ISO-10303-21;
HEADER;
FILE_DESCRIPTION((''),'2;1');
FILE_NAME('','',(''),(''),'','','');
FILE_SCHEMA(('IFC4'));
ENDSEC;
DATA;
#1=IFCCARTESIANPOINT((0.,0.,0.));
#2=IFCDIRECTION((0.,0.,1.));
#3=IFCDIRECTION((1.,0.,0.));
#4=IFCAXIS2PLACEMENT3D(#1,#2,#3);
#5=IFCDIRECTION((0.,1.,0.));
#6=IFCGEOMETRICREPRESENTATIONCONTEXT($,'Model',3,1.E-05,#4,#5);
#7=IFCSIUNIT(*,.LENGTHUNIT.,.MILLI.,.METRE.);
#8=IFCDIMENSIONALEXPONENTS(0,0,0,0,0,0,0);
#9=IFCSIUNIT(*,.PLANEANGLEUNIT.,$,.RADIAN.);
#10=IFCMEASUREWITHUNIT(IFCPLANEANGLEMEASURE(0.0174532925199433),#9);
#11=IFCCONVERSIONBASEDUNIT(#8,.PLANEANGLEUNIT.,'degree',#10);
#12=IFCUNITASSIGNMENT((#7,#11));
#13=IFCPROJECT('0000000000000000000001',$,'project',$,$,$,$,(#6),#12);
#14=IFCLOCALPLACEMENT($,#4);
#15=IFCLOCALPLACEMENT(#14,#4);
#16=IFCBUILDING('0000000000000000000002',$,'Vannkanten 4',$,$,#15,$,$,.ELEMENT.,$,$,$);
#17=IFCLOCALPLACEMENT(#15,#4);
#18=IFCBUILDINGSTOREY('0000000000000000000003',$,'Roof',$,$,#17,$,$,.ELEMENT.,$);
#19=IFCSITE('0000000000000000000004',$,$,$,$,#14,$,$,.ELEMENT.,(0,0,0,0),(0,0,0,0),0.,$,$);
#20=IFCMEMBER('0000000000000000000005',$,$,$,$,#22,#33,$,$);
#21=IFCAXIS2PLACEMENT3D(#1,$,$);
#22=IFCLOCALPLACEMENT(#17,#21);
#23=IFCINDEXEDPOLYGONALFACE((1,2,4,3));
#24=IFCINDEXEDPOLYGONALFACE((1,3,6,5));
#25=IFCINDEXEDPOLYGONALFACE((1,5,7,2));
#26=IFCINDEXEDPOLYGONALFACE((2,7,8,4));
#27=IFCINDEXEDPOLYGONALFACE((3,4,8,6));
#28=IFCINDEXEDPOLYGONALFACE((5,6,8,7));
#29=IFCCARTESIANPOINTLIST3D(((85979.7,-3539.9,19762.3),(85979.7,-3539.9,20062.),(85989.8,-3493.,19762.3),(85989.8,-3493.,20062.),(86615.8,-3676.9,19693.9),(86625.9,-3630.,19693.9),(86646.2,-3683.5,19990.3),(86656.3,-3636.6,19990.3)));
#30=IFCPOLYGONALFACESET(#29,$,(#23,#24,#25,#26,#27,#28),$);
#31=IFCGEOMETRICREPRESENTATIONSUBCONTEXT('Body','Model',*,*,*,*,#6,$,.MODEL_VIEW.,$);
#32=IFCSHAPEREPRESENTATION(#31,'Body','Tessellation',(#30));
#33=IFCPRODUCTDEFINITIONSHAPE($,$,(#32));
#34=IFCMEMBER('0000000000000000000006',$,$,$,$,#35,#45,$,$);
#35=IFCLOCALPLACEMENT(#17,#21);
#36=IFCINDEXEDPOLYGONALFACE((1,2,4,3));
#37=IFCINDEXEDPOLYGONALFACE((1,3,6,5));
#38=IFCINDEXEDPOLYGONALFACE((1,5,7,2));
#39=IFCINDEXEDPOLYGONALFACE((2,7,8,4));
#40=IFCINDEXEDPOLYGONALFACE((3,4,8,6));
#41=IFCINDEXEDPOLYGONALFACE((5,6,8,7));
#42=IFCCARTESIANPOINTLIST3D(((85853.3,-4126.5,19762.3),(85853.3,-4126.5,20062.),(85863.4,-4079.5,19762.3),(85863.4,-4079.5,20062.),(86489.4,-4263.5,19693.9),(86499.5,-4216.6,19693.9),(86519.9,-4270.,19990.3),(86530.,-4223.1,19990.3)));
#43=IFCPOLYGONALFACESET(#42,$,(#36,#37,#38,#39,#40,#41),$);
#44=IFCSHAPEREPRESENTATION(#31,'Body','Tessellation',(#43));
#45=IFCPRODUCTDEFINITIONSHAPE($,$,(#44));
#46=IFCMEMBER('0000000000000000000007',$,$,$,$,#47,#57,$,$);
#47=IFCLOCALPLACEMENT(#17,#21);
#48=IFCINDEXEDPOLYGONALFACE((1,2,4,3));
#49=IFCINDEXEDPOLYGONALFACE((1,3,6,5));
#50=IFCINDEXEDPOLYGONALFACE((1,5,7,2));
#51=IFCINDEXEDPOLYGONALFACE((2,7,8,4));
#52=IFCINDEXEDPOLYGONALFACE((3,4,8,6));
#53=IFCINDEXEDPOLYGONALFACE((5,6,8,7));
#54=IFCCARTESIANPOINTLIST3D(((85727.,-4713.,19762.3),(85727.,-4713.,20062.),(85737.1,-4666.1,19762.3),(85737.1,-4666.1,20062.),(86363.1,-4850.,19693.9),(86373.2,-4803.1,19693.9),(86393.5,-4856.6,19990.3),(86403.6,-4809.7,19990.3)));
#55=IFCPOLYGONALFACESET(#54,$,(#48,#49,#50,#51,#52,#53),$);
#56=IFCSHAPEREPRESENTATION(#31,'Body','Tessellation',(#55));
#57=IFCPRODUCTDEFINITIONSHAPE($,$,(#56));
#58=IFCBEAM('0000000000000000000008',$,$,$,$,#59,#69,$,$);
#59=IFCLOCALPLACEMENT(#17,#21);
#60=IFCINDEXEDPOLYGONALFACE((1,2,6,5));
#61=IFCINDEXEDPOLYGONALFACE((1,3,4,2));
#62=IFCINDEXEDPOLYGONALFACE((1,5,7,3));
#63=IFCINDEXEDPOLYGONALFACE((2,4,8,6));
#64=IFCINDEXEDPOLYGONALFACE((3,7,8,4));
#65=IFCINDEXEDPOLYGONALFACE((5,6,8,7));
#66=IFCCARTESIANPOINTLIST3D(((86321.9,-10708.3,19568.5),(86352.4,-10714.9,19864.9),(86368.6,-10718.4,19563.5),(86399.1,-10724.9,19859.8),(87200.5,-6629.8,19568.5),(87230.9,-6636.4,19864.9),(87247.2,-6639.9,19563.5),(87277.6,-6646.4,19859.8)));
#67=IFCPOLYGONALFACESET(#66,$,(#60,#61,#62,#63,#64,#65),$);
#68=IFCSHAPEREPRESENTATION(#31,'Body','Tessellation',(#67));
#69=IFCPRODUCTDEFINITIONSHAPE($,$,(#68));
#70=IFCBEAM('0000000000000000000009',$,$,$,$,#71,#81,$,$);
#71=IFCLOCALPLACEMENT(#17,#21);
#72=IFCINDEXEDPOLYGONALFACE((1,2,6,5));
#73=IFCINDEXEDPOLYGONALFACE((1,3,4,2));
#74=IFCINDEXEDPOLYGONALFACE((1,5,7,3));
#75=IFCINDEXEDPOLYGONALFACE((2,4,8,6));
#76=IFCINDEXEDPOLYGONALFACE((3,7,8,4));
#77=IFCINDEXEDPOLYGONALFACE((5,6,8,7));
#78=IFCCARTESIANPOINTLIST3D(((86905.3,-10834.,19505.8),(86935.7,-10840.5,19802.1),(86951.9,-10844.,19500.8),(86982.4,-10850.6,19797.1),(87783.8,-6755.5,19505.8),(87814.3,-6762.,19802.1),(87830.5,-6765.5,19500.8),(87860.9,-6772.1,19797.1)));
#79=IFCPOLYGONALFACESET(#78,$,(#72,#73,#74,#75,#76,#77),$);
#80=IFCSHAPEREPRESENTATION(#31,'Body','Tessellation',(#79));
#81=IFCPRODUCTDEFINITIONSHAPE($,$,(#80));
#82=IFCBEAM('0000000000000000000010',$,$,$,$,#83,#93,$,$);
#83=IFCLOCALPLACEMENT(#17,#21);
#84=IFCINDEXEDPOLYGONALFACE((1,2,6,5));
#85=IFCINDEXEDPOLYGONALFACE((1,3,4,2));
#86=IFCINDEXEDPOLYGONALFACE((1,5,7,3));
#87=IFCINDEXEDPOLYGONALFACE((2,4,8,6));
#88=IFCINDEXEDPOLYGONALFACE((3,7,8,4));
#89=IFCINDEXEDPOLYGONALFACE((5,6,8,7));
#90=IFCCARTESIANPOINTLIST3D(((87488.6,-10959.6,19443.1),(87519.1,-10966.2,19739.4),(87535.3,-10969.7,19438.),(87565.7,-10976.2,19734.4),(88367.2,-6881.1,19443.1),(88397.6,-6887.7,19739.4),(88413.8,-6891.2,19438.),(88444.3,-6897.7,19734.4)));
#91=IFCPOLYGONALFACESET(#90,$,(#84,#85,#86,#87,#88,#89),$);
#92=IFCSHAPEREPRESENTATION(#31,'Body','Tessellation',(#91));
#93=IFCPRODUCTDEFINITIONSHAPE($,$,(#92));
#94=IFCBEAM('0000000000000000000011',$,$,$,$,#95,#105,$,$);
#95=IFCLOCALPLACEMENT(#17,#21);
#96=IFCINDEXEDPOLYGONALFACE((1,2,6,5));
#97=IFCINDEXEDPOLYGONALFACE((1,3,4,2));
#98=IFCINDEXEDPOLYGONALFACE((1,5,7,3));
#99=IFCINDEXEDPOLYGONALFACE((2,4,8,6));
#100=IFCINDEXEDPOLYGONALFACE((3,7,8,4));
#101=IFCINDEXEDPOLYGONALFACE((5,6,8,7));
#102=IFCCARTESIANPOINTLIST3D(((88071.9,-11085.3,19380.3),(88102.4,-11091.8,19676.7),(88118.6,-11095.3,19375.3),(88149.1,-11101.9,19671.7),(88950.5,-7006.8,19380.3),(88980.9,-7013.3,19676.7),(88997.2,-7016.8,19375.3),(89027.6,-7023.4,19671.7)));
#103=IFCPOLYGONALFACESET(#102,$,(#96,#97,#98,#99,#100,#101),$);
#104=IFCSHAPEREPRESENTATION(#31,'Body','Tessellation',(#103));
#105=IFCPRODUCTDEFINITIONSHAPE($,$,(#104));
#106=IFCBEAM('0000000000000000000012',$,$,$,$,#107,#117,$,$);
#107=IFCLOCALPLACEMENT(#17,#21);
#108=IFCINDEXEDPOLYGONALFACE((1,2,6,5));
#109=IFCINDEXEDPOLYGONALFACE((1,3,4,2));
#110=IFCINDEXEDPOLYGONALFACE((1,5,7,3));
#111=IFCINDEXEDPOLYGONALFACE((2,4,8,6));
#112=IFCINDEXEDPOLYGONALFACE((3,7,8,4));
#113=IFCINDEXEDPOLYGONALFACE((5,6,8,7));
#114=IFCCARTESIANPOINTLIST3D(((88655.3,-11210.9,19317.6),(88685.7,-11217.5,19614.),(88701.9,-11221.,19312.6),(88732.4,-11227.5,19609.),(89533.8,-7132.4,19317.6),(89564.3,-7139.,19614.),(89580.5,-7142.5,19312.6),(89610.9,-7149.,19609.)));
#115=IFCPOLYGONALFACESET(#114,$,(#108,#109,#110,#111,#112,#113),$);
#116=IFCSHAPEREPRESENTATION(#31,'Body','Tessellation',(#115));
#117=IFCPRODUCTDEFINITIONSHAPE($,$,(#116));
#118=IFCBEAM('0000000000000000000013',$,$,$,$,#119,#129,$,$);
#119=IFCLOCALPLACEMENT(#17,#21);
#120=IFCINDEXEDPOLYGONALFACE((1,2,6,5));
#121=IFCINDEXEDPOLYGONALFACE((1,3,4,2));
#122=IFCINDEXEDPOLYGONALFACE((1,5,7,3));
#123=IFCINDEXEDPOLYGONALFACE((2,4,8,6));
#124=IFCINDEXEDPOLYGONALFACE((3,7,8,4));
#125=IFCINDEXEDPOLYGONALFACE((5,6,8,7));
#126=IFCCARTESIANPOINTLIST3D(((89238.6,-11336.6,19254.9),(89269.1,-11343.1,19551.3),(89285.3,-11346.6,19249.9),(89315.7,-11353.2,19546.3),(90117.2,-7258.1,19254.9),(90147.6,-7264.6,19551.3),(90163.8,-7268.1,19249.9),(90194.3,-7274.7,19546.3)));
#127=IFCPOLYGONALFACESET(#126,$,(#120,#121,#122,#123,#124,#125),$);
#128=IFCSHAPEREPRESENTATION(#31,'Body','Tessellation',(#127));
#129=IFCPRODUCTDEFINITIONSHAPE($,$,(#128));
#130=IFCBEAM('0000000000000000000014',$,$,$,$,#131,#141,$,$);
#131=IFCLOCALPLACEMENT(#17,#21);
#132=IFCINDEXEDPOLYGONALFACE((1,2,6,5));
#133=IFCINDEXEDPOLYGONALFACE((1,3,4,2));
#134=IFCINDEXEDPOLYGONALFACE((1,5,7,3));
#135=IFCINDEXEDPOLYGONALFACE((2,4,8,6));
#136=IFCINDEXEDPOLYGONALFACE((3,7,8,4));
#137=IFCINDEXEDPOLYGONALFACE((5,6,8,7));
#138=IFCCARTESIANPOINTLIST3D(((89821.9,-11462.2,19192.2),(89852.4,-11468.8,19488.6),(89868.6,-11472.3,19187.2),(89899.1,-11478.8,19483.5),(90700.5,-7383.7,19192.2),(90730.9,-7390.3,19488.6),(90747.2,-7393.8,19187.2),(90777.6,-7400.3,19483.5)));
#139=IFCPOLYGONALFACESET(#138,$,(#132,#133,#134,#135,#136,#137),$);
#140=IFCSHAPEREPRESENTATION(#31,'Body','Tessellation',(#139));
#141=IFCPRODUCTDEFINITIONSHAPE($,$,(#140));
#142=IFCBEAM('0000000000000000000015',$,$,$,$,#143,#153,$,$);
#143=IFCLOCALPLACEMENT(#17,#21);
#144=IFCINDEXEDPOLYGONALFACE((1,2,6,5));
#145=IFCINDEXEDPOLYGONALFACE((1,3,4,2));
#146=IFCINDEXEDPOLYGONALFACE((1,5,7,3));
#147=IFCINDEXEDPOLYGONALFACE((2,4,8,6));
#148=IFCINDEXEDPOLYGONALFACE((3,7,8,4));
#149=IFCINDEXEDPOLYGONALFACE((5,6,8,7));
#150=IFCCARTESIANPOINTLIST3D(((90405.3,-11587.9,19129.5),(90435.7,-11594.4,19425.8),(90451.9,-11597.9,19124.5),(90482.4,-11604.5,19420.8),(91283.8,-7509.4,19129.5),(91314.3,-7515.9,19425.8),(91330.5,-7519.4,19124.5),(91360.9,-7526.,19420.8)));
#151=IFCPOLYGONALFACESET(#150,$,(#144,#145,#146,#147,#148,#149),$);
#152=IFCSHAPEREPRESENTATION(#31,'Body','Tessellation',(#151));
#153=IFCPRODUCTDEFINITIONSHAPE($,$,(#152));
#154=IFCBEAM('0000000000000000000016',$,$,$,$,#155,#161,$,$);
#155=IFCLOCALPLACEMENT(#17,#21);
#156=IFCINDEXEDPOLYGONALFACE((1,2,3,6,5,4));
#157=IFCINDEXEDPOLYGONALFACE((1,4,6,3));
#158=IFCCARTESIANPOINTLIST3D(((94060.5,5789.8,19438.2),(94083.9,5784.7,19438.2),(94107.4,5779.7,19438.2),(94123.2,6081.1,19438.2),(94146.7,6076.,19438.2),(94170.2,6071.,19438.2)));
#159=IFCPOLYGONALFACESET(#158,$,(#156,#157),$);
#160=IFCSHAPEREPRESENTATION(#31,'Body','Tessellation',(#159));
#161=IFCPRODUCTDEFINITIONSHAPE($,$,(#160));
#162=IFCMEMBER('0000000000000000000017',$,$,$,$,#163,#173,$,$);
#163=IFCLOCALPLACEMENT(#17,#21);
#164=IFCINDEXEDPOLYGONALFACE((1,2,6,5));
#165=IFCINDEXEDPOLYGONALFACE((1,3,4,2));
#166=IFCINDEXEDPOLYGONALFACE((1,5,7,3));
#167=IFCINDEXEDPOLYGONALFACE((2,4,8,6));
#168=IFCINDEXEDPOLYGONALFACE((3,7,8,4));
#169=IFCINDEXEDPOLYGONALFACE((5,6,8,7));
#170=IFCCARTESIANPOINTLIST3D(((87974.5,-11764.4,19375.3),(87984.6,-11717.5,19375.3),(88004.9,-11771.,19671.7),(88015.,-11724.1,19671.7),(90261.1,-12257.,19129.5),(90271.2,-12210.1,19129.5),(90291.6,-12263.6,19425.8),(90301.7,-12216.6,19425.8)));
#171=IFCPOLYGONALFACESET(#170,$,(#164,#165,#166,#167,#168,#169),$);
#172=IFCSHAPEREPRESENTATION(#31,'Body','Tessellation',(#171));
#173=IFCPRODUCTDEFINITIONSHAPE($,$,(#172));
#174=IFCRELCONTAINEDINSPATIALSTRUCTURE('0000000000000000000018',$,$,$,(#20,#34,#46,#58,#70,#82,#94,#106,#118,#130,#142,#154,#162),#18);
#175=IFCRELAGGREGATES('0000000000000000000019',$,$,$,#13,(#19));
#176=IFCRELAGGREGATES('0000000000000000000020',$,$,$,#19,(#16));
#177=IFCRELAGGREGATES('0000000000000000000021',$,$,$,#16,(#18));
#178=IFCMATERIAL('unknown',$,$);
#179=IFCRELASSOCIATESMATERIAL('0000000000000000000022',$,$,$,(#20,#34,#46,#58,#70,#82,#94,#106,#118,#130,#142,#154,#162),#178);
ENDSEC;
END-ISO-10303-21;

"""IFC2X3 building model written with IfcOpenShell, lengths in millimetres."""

from ifc_helpers import new_model, entity, si_unit, converted_unit, direction, frame, origin_with_axes, place, context, subcontext, project, spatial, polyline, segment, composite_curve, outline, extrude, clip, halfspace, material, element, save


model = new_model("IFC2X3")

# Units and contexts
model_context = context("Model", 3, precision=1e-05, world=origin_with_axes(), true_north=direction((0.0, 1.0, 0.0)))
body_context = subcontext(model_context, "Body", "Model", "MODEL_VIEW")
ifc_project = project(units=[si_unit("LENGTHUNIT", "METRE", prefix="MILLI"), converted_unit("PLANEANGLEUNIT", "degree", entity("IfcPlaneAngleMeasure", 0.0174532925199433), si_unit("PLANEANGLEUNIT", "RADIAN"), dimensions=[0, 0, 0, 0, 0, 0, 0])], contexts=[model_context])

# Site, building, storey
site_placement = place(None, origin_with_axes())
site = spatial("IfcSite", under=ifc_project, at=site_placement, CompositionType="ELEMENT", RefLatitude=(0, 0, 0, 0), RefLongitude=(0, 0, 0, 0), RefElevation=0.0)
building_placement = place(site_placement, origin_with_axes())
building = spatial("IfcBuilding", under=site, at=building_placement, Name="Vannkanten 4", CompositionType="ELEMENT")
storey_placement = place(building_placement, origin_with_axes())
storey = spatial("IfcBuildingStorey", under=building, at=storey_placement, Name="Roof", CompositionType="ELEMENT")

# Shared definitions
ifc_material = material(Name="unknown")

# Members
member_1_placement = place(storey_placement, frame((86636.1, -3656.8, 19842.1), z_axis=(-0.972221, 0.209428, 0.104528), x_axis=(-0.210582, -0.977576, 0.0)))
element("IfcMember", 1, at=member_1_placement, inside=storey, material=ifc_material, context=body_context, shape_type="Clipping", body=[
    clip(extrude(outline(composite_curve([segment(polyline([(-24.0, -149.0), (-24.0, 149.0), (24.0, 149.0), (24.0, -149.0), (-24.0, -149.0)]), True, "CONTINUOUS")], self_intersect=False)), frame((0.0, 0.0, 0.0), z_axis=(0.0, 0.0, 1.0), x_axis=(1.0, 0.0, 0.0)), (0.0, 0.0, 1.0), 1028.4), halfspace(frame((-24.0, -149.0, 654.3), z_axis=(0.0, 0.104528, -0.994522), x_axis=(0.0, -0.994522, -0.104528)), True)),
])
member_2_placement = place(storey_placement, frame((86509.7, -4243.3, 19842.1), z_axis=(-0.972221, 0.209428, 0.104528), x_axis=(-0.210582, -0.977576, 0.0)))
element("IfcMember", 2, at=member_2_placement, inside=storey, material=ifc_material, context=body_context, shape_type="Clipping", body=[
    clip(extrude(outline(composite_curve([segment(polyline([(-24.0, -149.0), (-24.0, 149.0), (24.0, 149.0), (24.0, -149.0), (-24.0, -149.0)]), True, "CONTINUOUS")], self_intersect=False)), frame((0.0, 0.0, 0.0), z_axis=(0.0, 0.0, 1.0), x_axis=(1.0, 0.0, 0.0)), (0.0, 0.0, 1.0), 1028.4), halfspace(frame((-24.0, -149.0, 654.3), z_axis=(0.0, 0.104528, -0.994522), x_axis=(0.0, -0.994522, -0.104528)), True)),
])
member_3_placement = place(storey_placement, frame((86383.4, -4829.8, 19842.1), z_axis=(-0.972221, 0.209428, 0.104528), x_axis=(-0.210582, -0.977576, 0.0)))
element("IfcMember", 3, at=member_3_placement, inside=storey, material=ifc_material, context=body_context, shape_type="Clipping", body=[
    clip(extrude(outline(composite_curve([segment(polyline([(-24.0, -149.0), (-24.0, 149.0), (24.0, 149.0), (24.0, -149.0), (-24.0, -149.0)]), True, "CONTINUOUS")], self_intersect=False)), frame((0.0, 0.0, 0.0), z_axis=(0.0, 0.0, 1.0), x_axis=(1.0, 0.0, 0.0)), (0.0, 0.0, 1.0), 1028.4), halfspace(frame((-24.0, -149.0, 654.3), z_axis=(0.0, 0.104528, -0.994522), x_axis=(0.0, -0.994522, -0.104528)), True)),
])

# Beams
beam_1_placement = place(storey_placement, frame((86360.5, -10716.6, 19714.2), z_axis=(0.210582, 0.977576, 0.0), x_axis=(-0.972221, 0.209428, 0.104528)))
element("IfcBeam", 4, at=beam_1_placement, inside=storey, material=ifc_material, context=body_context, shape_type="SweptSolid", body=[
    extrude(outline(composite_curve([segment(polyline([(-24.0, -149.0), (-24.0, 149.0), (24.0, 149.0), (24.0, -149.0), (-24.0, -149.0)]), True, "CONTINUOUS")], self_intersect=False)), frame((0.0, 0.0, 0.0), z_axis=(0.0, 0.0, 1.0), x_axis=(1.0, 0.0, 0.0)), (0.0, 0.0, 1.0), 4172.0),
])
beam_2_placement = place(storey_placement, frame((86943.8, -10842.3, 19651.4), z_axis=(0.210582, 0.977576, 0.0), x_axis=(-0.972221, 0.209428, 0.104528)))
element("IfcBeam", 5, at=beam_2_placement, inside=storey, material=ifc_material, context=body_context, shape_type="SweptSolid", body=[
    extrude(outline(composite_curve([segment(polyline([(-24.0, -149.0), (-24.0, 149.0), (24.0, 149.0), (24.0, -149.0), (-24.0, -149.0)]), True, "CONTINUOUS")], self_intersect=False)), frame((0.0, 0.0, 0.0), z_axis=(0.0, 0.0, 1.0), x_axis=(1.0, 0.0, 0.0)), (0.0, 0.0, 1.0), 4172.0),
])
beam_3_placement = place(storey_placement, frame((87527.2, -10967.9, 19588.7), z_axis=(0.210582, 0.977576, 0.0), x_axis=(-0.972221, 0.209428, 0.104528)))
element("IfcBeam", 6, at=beam_3_placement, inside=storey, material=ifc_material, context=body_context, shape_type="SweptSolid", body=[
    extrude(outline(composite_curve([segment(polyline([(-24.0, -149.0), (-24.0, 149.0), (24.0, 149.0), (24.0, -149.0), (-24.0, -149.0)]), True, "CONTINUOUS")], self_intersect=False)), frame((0.0, 0.0, 0.0), z_axis=(0.0, 0.0, 1.0), x_axis=(1.0, 0.0, 0.0)), (0.0, 0.0, 1.0), 4172.0),
])
beam_4_placement = place(storey_placement, frame((88110.5, -11093.6, 19526.0), z_axis=(0.210582, 0.977576, 0.0), x_axis=(-0.972221, 0.209428, 0.104528)))
element("IfcBeam", 7, at=beam_4_placement, inside=storey, material=ifc_material, context=body_context, shape_type="SweptSolid", body=[
    extrude(outline(composite_curve([segment(polyline([(-24.0, -149.0), (-24.0, 149.0), (24.0, 149.0), (24.0, -149.0), (-24.0, -149.0)]), True, "CONTINUOUS")], self_intersect=False)), frame((0.0, 0.0, 0.0), z_axis=(0.0, 0.0, 1.0), x_axis=(1.0, 0.0, 0.0)), (0.0, 0.0, 1.0), 4172.0),
])
beam_5_placement = place(storey_placement, frame((88693.8, -11219.2, 19463.3), z_axis=(0.210582, 0.977576, 0.0), x_axis=(-0.972221, 0.209428, 0.104528)))
element("IfcBeam", 8, at=beam_5_placement, inside=storey, material=ifc_material, context=body_context, shape_type="SweptSolid", body=[
    extrude(outline(composite_curve([segment(polyline([(-24.0, -149.0), (-24.0, 149.0), (24.0, 149.0), (24.0, -149.0), (-24.0, -149.0)]), True, "CONTINUOUS")], self_intersect=False)), frame((0.0, 0.0, 0.0), z_axis=(0.0, 0.0, 1.0), x_axis=(1.0, 0.0, 0.0)), (0.0, 0.0, 1.0), 4172.0),
])
beam_6_placement = place(storey_placement, frame((89277.2, -11344.9, 19400.6), z_axis=(0.210582, 0.977576, 0.0), x_axis=(-0.972221, 0.209428, 0.104528)))
element("IfcBeam", 9, at=beam_6_placement, inside=storey, material=ifc_material, context=body_context, shape_type="SweptSolid", body=[
    extrude(outline(composite_curve([segment(polyline([(-24.0, -149.0), (-24.0, 149.0), (24.0, 149.0), (24.0, -149.0), (-24.0, -149.0)]), True, "CONTINUOUS")], self_intersect=False)), frame((0.0, 0.0, 0.0), z_axis=(0.0, 0.0, 1.0), x_axis=(1.0, 0.0, 0.0)), (0.0, 0.0, 1.0), 4172.0),
])
beam_7_placement = place(storey_placement, frame((89860.5, -11470.5, 19337.9), z_axis=(0.210582, 0.977576, 0.0), x_axis=(-0.972221, 0.209428, 0.104528)))
element("IfcBeam", 10, at=beam_7_placement, inside=storey, material=ifc_material, context=body_context, shape_type="SweptSolid", body=[
    extrude(outline(composite_curve([segment(polyline([(-24.0, -149.0), (-24.0, 149.0), (24.0, 149.0), (24.0, -149.0), (-24.0, -149.0)]), True, "CONTINUOUS")], self_intersect=False)), frame((0.0, 0.0, 0.0), z_axis=(0.0, 0.0, 1.0), x_axis=(1.0, 0.0, 0.0)), (0.0, 0.0, 1.0), 4172.0),
])
beam_8_placement = place(storey_placement, frame((90443.8, -11596.2, 19275.1), z_axis=(0.210582, 0.977576, 0.0), x_axis=(-0.972221, 0.209428, 0.104528)))
element("IfcBeam", 11, at=beam_8_placement, inside=storey, material=ifc_material, context=body_context, shape_type="SweptSolid", body=[
    extrude(outline(composite_curve([segment(polyline([(-24.0, -149.0), (-24.0, 149.0), (24.0, 149.0), (24.0, -149.0), (-24.0, -149.0)]), True, "CONTINUOUS")], self_intersect=False)), frame((0.0, 0.0, 0.0), z_axis=(0.0, 0.0, 1.0), x_axis=(1.0, 0.0, 0.0)), (0.0, 0.0, 1.0), 4172.0),
])
beam_9_placement = place(storey_placement, frame((90053.4, -12926.3, 19289.2), z_axis=(0.210582, 0.977576, 0.0), x_axis=(-0.977576, 0.210582, 0.0)))
element("IfcBeam", 12, at=beam_9_placement, inside=storey, material=ifc_material, context=body_context, shape_type="SweptSolid", body=[
    extrude(outline(composite_curve([segment(polyline([(24.0, 149.0), (0.0, 149.0), (-24.0, 149.0), (-24.0, 149.0), (24.0, 149.0), (24.0, 149.0)]), True, "CONTINUOUS")], self_intersect=False)), frame((0.0, 0.0, 19438.2), z_axis=(0.0, 0.0, -1.0), x_axis=(-1.0, 0.0, 0.0)), (0.0, 0.0, 1.0), 298.0),
])

# Member
member_4_placement = place(storey_placement, frame((90281.4, -12236.8, 19277.7), z_axis=(-0.972221, 0.209428, 0.104528), x_axis=(-0.210582, -0.977576, 0.0)))
element("IfcMember", 13, at=member_4_placement, inside=storey, material=ifc_material, context=body_context, shape_type="SweptSolid", body=[
    extrude(outline(composite_curve([segment(polyline([(-24.0, -149.0), (-24.0, 149.0), (24.0, 149.0), (24.0, -149.0), (-24.0, -149.0)]), True, "CONTINUOUS")], self_intersect=False)), frame((0.0, 0.0, 0.0), z_axis=(0.0, 0.0, 1.0), x_axis=(1.0, 0.0, 0.0)), (0.0, 0.0, 1.0), 2352.0),
])

save(model, "model.ifc")
